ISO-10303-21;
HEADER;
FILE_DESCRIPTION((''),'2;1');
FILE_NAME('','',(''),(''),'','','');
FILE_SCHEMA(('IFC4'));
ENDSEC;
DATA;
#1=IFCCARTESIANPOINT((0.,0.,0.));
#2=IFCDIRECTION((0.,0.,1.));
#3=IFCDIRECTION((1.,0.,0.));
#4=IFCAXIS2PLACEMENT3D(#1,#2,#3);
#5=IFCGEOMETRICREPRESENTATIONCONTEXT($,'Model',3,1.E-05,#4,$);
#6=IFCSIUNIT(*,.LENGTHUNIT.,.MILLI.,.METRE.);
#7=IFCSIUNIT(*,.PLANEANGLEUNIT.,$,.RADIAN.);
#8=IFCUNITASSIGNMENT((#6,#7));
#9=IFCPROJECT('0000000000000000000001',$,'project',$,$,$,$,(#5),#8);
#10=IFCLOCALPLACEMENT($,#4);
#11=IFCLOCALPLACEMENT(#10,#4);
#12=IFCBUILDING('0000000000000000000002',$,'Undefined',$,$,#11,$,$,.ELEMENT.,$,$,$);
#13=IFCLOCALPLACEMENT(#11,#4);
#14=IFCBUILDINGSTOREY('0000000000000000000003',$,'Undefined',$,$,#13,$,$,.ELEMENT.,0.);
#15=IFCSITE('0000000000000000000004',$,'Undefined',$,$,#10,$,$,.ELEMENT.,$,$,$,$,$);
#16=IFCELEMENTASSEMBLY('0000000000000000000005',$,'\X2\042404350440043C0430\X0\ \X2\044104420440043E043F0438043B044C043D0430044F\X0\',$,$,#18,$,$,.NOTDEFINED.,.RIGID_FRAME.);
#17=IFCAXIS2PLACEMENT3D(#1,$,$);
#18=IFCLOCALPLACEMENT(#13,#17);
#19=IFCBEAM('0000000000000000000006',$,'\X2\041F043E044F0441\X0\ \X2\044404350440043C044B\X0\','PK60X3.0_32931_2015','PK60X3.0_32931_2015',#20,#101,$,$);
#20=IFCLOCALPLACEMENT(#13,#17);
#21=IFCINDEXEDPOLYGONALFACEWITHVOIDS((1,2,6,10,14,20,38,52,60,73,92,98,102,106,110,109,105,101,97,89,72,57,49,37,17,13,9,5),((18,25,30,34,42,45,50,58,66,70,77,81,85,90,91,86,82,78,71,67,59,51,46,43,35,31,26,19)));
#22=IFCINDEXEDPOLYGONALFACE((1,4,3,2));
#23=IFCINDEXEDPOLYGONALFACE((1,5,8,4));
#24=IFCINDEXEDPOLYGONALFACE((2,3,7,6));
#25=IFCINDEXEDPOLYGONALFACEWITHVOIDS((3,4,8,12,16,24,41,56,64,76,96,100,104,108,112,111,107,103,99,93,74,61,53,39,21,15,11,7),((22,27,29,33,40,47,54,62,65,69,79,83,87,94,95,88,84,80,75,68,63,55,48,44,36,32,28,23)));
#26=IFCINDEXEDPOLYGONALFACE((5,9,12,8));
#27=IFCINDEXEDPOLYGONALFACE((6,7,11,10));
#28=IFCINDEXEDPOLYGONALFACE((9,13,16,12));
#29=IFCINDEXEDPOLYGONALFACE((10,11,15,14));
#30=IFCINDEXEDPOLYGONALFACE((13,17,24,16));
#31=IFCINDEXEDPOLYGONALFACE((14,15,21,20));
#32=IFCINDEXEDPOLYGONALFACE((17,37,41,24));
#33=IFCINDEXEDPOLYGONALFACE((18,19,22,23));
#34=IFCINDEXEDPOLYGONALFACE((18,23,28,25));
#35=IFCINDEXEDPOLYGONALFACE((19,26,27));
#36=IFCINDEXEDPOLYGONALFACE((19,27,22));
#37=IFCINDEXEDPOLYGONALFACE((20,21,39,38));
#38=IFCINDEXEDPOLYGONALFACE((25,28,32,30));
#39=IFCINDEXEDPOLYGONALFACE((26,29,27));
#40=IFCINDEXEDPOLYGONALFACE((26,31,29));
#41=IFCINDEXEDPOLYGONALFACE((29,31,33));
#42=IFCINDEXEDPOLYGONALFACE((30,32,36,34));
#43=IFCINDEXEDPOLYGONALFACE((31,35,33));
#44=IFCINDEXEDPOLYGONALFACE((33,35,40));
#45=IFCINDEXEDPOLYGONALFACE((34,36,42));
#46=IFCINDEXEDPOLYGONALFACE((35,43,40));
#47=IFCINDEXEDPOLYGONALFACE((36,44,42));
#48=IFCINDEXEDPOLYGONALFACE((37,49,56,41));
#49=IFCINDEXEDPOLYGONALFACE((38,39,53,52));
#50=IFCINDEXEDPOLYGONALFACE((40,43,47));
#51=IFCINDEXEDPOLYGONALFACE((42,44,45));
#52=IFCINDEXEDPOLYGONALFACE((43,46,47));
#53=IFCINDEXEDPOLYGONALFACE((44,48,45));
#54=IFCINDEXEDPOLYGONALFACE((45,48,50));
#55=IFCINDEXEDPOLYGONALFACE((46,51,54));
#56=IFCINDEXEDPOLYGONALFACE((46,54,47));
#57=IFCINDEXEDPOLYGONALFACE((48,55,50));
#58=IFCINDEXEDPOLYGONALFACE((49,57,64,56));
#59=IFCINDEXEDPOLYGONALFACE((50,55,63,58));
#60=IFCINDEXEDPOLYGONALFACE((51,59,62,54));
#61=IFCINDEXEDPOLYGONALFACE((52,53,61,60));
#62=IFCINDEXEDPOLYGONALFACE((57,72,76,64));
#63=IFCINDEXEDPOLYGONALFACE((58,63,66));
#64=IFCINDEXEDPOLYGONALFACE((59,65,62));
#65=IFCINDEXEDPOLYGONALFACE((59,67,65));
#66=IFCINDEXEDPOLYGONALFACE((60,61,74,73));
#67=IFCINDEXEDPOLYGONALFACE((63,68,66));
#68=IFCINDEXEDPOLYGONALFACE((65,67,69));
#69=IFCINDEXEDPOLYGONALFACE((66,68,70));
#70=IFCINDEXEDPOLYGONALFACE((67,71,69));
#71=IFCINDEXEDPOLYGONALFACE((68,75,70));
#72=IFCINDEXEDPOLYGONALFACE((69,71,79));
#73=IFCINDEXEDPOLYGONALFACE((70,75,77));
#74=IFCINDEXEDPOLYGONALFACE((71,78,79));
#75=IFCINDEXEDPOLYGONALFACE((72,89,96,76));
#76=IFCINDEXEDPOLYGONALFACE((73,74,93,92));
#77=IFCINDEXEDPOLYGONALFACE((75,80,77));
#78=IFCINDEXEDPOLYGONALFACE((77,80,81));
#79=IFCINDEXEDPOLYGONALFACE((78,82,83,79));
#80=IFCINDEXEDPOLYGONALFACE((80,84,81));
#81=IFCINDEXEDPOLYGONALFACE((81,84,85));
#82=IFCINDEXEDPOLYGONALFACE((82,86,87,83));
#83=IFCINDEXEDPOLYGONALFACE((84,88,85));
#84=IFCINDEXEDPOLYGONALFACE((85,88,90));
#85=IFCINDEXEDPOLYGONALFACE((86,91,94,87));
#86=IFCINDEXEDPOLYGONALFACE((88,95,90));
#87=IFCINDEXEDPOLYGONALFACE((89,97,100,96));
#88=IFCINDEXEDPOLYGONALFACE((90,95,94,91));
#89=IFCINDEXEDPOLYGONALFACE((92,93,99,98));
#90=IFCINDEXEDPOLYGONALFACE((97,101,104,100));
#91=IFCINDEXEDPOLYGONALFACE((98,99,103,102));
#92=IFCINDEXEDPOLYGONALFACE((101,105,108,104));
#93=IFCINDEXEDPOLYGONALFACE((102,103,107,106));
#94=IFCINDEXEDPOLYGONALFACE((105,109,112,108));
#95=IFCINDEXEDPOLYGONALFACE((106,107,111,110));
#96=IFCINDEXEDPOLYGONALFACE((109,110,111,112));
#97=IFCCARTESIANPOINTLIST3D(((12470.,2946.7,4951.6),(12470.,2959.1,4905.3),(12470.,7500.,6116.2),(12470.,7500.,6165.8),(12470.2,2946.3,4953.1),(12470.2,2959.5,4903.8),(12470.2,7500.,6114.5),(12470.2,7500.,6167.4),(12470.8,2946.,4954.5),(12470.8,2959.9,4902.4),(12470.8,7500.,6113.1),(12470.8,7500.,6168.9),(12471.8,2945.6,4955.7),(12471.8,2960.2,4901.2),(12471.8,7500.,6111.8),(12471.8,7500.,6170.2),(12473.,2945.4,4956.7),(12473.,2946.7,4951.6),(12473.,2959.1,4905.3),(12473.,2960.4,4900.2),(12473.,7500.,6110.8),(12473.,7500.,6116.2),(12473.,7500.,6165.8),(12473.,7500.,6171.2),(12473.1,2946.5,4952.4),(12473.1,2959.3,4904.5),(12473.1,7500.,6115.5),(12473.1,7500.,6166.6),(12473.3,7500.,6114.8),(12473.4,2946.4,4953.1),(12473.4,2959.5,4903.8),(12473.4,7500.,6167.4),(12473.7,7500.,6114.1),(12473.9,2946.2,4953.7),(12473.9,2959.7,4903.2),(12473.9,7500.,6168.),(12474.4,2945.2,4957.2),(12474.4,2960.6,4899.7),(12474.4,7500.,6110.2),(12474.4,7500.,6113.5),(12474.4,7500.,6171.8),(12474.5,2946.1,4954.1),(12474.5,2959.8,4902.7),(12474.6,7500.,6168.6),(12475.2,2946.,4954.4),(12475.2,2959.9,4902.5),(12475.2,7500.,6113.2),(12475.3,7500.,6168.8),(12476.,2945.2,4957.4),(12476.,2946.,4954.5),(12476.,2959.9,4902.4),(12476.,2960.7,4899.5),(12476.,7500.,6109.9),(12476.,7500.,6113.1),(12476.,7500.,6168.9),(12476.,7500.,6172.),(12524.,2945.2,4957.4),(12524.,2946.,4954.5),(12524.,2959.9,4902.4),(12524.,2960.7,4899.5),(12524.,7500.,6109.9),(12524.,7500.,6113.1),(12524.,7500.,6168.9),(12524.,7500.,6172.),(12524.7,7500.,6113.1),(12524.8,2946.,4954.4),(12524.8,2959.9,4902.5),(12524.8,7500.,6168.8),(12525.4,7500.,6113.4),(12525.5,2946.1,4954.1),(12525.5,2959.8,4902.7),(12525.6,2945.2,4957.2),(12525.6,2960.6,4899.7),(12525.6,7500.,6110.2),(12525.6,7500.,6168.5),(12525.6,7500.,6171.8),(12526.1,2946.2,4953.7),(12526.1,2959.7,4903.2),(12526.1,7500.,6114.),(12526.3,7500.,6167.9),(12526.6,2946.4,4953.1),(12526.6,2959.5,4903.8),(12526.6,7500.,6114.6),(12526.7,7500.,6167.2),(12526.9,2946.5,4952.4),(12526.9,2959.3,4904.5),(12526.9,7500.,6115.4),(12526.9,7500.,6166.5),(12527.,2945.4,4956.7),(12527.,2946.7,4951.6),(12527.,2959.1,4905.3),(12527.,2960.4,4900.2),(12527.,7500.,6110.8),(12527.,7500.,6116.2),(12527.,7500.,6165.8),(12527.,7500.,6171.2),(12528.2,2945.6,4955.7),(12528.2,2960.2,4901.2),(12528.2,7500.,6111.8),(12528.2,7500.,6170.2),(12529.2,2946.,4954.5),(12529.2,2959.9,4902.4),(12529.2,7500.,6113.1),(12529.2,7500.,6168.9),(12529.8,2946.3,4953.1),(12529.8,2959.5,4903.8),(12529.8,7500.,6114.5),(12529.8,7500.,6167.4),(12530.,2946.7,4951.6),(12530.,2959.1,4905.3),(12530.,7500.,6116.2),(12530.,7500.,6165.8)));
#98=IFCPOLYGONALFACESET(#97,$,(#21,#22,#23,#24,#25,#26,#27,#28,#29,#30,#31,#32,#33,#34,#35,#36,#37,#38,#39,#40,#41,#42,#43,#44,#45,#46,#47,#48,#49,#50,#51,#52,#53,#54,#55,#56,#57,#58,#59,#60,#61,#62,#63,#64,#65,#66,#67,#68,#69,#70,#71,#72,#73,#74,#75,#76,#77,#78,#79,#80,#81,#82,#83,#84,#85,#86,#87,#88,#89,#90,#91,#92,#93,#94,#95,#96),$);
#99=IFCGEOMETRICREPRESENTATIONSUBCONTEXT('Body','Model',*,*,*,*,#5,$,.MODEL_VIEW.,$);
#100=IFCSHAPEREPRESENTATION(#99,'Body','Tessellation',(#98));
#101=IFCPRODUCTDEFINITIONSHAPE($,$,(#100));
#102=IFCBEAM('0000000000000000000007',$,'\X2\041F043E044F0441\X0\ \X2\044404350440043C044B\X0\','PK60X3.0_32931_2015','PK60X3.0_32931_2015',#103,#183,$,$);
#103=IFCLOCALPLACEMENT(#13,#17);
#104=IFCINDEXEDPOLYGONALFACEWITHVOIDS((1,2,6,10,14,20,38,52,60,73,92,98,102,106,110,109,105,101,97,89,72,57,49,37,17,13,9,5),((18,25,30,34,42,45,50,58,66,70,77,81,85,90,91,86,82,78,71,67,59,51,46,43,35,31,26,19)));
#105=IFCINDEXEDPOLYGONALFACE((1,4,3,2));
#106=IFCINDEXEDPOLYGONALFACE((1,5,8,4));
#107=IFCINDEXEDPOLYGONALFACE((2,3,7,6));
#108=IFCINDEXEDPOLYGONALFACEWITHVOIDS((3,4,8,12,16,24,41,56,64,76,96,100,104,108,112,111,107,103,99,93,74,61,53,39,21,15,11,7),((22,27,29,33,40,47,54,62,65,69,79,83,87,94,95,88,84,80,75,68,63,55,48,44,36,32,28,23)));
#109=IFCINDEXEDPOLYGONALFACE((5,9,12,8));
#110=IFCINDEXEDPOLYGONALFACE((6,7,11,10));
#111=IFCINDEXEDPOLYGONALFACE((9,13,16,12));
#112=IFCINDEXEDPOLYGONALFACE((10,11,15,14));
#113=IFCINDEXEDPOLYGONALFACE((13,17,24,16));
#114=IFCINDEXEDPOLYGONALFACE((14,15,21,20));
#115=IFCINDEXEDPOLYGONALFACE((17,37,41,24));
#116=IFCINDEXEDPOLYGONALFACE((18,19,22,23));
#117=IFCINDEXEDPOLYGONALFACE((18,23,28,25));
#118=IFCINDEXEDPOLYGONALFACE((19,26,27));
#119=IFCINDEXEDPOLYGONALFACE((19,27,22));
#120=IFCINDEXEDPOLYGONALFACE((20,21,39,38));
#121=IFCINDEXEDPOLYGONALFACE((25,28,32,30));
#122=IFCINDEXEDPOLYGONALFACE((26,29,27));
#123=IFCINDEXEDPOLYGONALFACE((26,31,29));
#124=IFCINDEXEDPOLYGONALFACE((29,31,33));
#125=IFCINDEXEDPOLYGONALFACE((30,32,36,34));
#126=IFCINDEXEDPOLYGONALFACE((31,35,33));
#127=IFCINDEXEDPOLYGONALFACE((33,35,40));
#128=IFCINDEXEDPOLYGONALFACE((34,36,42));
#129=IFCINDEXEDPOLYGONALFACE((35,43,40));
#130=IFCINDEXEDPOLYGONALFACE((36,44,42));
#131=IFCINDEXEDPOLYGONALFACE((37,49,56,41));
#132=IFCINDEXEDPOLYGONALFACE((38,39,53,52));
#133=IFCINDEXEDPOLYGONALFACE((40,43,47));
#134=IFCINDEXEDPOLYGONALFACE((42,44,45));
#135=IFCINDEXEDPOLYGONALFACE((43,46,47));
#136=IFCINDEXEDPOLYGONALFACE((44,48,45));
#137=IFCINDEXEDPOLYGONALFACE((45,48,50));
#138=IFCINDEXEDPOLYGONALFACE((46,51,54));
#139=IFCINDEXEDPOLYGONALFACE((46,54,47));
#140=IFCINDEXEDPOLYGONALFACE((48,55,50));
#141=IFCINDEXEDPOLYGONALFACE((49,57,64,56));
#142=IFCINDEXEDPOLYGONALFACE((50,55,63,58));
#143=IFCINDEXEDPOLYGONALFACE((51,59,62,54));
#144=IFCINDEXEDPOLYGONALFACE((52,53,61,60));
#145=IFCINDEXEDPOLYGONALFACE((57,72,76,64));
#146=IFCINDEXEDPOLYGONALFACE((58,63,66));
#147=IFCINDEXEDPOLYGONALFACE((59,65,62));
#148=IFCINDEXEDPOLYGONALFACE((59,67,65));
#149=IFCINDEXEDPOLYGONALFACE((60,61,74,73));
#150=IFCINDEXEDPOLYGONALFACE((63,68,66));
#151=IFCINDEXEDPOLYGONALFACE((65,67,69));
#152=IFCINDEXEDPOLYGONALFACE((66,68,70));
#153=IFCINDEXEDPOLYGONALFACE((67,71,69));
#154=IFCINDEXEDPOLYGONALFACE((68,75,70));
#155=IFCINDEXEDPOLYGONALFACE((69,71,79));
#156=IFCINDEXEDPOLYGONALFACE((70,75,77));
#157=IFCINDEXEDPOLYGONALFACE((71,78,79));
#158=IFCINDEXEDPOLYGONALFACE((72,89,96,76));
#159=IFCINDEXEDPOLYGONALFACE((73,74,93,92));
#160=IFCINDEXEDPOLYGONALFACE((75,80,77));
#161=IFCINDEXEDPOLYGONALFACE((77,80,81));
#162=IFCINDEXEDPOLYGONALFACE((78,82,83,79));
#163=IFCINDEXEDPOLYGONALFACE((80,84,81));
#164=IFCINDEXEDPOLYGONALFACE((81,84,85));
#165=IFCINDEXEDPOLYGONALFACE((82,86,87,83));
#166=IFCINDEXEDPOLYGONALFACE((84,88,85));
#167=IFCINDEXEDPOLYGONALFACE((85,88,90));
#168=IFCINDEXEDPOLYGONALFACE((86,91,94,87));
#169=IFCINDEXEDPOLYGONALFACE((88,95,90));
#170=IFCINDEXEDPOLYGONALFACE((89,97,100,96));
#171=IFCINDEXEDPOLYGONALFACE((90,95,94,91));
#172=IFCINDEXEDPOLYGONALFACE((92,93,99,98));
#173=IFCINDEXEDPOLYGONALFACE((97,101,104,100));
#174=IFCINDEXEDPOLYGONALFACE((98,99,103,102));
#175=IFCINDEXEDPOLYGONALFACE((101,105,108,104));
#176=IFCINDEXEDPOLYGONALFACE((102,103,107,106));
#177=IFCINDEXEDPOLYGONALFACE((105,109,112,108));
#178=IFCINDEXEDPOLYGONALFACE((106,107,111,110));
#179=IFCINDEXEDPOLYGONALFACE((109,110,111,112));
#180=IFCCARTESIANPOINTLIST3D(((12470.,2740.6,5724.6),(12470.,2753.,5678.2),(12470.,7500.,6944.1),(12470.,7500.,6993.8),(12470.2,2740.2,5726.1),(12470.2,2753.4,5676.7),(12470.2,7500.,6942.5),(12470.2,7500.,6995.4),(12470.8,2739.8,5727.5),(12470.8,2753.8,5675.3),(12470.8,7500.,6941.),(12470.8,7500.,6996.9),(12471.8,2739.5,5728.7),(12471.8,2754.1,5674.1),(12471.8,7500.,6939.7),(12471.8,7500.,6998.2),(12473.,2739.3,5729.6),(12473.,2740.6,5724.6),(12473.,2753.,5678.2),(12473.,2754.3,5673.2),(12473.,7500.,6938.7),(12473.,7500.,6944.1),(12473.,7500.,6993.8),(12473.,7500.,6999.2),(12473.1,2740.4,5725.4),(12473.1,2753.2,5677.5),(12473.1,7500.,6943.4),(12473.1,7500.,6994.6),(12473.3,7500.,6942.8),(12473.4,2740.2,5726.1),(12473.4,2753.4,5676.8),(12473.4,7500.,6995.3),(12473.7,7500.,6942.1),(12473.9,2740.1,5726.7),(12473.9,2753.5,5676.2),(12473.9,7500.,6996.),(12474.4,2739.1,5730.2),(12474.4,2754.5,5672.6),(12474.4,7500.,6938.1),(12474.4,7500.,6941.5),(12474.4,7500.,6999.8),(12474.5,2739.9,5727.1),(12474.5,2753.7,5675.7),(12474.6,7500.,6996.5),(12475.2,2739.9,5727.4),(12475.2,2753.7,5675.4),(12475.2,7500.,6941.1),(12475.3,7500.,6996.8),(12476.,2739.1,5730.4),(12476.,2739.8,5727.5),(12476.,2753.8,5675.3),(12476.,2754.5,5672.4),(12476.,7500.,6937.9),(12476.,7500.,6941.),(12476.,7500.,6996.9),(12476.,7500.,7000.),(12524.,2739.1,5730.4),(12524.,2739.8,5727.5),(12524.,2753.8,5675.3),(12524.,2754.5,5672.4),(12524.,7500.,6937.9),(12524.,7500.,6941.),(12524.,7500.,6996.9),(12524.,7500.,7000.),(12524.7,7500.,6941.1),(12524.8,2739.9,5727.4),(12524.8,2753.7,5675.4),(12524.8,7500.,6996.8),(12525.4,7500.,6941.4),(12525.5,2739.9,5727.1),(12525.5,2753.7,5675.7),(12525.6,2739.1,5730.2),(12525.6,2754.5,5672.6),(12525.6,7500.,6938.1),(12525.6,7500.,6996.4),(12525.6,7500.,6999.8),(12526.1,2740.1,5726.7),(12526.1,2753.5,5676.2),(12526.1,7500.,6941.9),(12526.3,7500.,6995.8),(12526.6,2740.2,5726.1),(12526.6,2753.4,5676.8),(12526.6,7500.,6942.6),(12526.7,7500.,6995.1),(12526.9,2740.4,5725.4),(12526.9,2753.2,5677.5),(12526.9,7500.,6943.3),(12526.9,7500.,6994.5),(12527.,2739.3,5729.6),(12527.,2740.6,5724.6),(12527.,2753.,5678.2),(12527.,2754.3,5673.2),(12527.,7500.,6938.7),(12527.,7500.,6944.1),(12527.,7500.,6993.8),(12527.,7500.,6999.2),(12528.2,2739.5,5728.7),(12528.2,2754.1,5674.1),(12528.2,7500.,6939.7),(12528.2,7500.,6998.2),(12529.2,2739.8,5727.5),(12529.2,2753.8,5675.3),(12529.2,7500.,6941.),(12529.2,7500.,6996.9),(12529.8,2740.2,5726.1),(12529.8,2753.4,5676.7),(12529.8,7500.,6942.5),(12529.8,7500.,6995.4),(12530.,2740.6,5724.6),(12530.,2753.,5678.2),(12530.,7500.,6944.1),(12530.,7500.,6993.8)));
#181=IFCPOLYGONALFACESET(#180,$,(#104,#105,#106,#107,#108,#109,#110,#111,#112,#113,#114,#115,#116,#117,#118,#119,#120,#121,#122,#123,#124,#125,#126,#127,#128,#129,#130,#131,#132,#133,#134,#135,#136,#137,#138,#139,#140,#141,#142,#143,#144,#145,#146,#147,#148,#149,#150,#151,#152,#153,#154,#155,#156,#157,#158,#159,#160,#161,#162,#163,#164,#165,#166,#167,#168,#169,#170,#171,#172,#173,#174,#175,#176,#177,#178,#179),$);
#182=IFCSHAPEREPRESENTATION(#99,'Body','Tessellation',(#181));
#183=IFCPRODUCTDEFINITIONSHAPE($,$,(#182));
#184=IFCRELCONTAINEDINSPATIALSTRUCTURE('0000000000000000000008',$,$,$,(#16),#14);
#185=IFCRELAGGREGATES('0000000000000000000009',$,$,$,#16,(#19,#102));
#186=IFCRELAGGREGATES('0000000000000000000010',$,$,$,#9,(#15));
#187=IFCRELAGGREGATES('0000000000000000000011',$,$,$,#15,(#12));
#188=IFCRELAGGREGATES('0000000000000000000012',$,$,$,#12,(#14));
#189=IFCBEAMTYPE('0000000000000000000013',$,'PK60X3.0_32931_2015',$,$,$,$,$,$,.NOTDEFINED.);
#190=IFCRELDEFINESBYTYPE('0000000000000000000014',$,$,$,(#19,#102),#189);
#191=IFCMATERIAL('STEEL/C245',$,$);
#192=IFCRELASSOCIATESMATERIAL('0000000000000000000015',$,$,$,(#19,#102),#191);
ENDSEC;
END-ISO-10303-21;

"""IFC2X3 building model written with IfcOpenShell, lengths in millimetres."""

from ifc_helpers import new_model, si_unit, frame, origin_with_axes, origin_2d_with_axis, place, context, subcontext, project, spatial, hollow_rectangle, extrude, clip, halfspace, material, type_object, element, aggregate, save


model = new_model("IFC2X3")

# Units and contexts
model_context = context("Model", 3, precision=1e-05, world=origin_with_axes())
body_context = subcontext(model_context, "Body", "Model", "MODEL_VIEW")
ifc_project = project(units=[si_unit("LENGTHUNIT", "METRE", prefix="MILLI"), si_unit("PLANEANGLEUNIT", "RADIAN")], contexts=[model_context])

# Site, building, storey
site_placement = place(None, origin_with_axes())
site = spatial("IfcSite", under=ifc_project, at=site_placement, Name="Undefined", CompositionType="ELEMENT")
building_placement = place(site_placement, origin_with_axes())
building = spatial("IfcBuilding", under=site, at=building_placement, Name="Undefined", CompositionType="ELEMENT")
storey_placement = place(building_placement, origin_with_axes())
storey = spatial("IfcBuildingStorey", under=building, at=storey_placement, Name="Undefined", CompositionType="ELEMENT", Elevation=0.0)

# Shared definitions
ifc_material_1 = material(Name="STEEL/C245")

# Element assembly, beams
beam_type_1 = type_object("IfcBeamType", Name="PK60X3.0_32931_2015", PredefinedType="NOTDEFINED")
assembly_1_placement = place(storey_placement, origin_with_axes())
assembly_1 = element("IfcElementAssembly", 1, at=assembly_1_placement, inside=storey, Name="Ферма стропильная", AssemblyPlace="NOTDEFINED", PredefinedType="RIGID_FRAME")
beam_1_placement = place(assembly_1_placement, frame((12500.0, 2952.9, 4928.4), z_axis=(0.0, -0.257663, 0.966235), x_axis=(0.0, 0.966235, 0.257663)))
beam_1 = element("IfcBeam", 2, at=beam_1_placement, type_object=beam_type_1, material=ifc_material_1, Name="Пояс фермы", Description="PK60X3.0_32931_2015", ObjectType="PK60X3.0_32931_2015", context=body_context, shape_type="Clipping", body=[
    clip(extrude(hollow_rectangle(XDim=60.0, YDim=60.0, WallThickness=3.0, InnerFilletRadius=3.0, OuterFilletRadius=6.0, at=origin_2d_with_axis()), frame((4729.1, 0.0, 0.0), z_axis=(-1.0, 0.0, 0.0), x_axis=(0.0, -1.0, 0.0)), (0.0, 0.0, 1.0), 4729.1), halfspace(frame((4938.1, 0.0, 870.5), z_axis=(0.966235, 0.0, -0.257663), x_axis=(0.0, -1.0, 0.0)), False)),
])
beam_2_placement = place(assembly_1_placement, frame((12500.0, 2746.8, 5701.4), z_axis=(0.0, -0.257663, 0.966235), x_axis=(0.0, 0.966235, 0.257663)))
beam_2 = element("IfcBeam", 3, at=beam_2_placement, type_object=beam_type_1, material=ifc_material_1, Name="Пояс фермы", Description="PK60X3.0_32931_2015", ObjectType="PK60X3.0_32931_2015", context=body_context, shape_type="Clipping", body=[
    clip(extrude(hollow_rectangle(XDim=60.0, YDim=60.0, WallThickness=3.0, InnerFilletRadius=3.0, OuterFilletRadius=6.0, at=origin_2d_with_axis()), frame((4942.5, 0.0, 0.0), z_axis=(-1.0, 0.0, 0.0), x_axis=(0.0, -1.0, 0.0)), (0.0, 0.0, 1.0), 4942.5), halfspace(frame((4938.1, 0.0, 70.5), z_axis=(0.966235, 0.0, -0.257663), x_axis=(0.0, -1.0, 0.0)), False)),
])

aggregate(assembly_1, [beam_1, beam_2])

save(model, "model.ifc")
